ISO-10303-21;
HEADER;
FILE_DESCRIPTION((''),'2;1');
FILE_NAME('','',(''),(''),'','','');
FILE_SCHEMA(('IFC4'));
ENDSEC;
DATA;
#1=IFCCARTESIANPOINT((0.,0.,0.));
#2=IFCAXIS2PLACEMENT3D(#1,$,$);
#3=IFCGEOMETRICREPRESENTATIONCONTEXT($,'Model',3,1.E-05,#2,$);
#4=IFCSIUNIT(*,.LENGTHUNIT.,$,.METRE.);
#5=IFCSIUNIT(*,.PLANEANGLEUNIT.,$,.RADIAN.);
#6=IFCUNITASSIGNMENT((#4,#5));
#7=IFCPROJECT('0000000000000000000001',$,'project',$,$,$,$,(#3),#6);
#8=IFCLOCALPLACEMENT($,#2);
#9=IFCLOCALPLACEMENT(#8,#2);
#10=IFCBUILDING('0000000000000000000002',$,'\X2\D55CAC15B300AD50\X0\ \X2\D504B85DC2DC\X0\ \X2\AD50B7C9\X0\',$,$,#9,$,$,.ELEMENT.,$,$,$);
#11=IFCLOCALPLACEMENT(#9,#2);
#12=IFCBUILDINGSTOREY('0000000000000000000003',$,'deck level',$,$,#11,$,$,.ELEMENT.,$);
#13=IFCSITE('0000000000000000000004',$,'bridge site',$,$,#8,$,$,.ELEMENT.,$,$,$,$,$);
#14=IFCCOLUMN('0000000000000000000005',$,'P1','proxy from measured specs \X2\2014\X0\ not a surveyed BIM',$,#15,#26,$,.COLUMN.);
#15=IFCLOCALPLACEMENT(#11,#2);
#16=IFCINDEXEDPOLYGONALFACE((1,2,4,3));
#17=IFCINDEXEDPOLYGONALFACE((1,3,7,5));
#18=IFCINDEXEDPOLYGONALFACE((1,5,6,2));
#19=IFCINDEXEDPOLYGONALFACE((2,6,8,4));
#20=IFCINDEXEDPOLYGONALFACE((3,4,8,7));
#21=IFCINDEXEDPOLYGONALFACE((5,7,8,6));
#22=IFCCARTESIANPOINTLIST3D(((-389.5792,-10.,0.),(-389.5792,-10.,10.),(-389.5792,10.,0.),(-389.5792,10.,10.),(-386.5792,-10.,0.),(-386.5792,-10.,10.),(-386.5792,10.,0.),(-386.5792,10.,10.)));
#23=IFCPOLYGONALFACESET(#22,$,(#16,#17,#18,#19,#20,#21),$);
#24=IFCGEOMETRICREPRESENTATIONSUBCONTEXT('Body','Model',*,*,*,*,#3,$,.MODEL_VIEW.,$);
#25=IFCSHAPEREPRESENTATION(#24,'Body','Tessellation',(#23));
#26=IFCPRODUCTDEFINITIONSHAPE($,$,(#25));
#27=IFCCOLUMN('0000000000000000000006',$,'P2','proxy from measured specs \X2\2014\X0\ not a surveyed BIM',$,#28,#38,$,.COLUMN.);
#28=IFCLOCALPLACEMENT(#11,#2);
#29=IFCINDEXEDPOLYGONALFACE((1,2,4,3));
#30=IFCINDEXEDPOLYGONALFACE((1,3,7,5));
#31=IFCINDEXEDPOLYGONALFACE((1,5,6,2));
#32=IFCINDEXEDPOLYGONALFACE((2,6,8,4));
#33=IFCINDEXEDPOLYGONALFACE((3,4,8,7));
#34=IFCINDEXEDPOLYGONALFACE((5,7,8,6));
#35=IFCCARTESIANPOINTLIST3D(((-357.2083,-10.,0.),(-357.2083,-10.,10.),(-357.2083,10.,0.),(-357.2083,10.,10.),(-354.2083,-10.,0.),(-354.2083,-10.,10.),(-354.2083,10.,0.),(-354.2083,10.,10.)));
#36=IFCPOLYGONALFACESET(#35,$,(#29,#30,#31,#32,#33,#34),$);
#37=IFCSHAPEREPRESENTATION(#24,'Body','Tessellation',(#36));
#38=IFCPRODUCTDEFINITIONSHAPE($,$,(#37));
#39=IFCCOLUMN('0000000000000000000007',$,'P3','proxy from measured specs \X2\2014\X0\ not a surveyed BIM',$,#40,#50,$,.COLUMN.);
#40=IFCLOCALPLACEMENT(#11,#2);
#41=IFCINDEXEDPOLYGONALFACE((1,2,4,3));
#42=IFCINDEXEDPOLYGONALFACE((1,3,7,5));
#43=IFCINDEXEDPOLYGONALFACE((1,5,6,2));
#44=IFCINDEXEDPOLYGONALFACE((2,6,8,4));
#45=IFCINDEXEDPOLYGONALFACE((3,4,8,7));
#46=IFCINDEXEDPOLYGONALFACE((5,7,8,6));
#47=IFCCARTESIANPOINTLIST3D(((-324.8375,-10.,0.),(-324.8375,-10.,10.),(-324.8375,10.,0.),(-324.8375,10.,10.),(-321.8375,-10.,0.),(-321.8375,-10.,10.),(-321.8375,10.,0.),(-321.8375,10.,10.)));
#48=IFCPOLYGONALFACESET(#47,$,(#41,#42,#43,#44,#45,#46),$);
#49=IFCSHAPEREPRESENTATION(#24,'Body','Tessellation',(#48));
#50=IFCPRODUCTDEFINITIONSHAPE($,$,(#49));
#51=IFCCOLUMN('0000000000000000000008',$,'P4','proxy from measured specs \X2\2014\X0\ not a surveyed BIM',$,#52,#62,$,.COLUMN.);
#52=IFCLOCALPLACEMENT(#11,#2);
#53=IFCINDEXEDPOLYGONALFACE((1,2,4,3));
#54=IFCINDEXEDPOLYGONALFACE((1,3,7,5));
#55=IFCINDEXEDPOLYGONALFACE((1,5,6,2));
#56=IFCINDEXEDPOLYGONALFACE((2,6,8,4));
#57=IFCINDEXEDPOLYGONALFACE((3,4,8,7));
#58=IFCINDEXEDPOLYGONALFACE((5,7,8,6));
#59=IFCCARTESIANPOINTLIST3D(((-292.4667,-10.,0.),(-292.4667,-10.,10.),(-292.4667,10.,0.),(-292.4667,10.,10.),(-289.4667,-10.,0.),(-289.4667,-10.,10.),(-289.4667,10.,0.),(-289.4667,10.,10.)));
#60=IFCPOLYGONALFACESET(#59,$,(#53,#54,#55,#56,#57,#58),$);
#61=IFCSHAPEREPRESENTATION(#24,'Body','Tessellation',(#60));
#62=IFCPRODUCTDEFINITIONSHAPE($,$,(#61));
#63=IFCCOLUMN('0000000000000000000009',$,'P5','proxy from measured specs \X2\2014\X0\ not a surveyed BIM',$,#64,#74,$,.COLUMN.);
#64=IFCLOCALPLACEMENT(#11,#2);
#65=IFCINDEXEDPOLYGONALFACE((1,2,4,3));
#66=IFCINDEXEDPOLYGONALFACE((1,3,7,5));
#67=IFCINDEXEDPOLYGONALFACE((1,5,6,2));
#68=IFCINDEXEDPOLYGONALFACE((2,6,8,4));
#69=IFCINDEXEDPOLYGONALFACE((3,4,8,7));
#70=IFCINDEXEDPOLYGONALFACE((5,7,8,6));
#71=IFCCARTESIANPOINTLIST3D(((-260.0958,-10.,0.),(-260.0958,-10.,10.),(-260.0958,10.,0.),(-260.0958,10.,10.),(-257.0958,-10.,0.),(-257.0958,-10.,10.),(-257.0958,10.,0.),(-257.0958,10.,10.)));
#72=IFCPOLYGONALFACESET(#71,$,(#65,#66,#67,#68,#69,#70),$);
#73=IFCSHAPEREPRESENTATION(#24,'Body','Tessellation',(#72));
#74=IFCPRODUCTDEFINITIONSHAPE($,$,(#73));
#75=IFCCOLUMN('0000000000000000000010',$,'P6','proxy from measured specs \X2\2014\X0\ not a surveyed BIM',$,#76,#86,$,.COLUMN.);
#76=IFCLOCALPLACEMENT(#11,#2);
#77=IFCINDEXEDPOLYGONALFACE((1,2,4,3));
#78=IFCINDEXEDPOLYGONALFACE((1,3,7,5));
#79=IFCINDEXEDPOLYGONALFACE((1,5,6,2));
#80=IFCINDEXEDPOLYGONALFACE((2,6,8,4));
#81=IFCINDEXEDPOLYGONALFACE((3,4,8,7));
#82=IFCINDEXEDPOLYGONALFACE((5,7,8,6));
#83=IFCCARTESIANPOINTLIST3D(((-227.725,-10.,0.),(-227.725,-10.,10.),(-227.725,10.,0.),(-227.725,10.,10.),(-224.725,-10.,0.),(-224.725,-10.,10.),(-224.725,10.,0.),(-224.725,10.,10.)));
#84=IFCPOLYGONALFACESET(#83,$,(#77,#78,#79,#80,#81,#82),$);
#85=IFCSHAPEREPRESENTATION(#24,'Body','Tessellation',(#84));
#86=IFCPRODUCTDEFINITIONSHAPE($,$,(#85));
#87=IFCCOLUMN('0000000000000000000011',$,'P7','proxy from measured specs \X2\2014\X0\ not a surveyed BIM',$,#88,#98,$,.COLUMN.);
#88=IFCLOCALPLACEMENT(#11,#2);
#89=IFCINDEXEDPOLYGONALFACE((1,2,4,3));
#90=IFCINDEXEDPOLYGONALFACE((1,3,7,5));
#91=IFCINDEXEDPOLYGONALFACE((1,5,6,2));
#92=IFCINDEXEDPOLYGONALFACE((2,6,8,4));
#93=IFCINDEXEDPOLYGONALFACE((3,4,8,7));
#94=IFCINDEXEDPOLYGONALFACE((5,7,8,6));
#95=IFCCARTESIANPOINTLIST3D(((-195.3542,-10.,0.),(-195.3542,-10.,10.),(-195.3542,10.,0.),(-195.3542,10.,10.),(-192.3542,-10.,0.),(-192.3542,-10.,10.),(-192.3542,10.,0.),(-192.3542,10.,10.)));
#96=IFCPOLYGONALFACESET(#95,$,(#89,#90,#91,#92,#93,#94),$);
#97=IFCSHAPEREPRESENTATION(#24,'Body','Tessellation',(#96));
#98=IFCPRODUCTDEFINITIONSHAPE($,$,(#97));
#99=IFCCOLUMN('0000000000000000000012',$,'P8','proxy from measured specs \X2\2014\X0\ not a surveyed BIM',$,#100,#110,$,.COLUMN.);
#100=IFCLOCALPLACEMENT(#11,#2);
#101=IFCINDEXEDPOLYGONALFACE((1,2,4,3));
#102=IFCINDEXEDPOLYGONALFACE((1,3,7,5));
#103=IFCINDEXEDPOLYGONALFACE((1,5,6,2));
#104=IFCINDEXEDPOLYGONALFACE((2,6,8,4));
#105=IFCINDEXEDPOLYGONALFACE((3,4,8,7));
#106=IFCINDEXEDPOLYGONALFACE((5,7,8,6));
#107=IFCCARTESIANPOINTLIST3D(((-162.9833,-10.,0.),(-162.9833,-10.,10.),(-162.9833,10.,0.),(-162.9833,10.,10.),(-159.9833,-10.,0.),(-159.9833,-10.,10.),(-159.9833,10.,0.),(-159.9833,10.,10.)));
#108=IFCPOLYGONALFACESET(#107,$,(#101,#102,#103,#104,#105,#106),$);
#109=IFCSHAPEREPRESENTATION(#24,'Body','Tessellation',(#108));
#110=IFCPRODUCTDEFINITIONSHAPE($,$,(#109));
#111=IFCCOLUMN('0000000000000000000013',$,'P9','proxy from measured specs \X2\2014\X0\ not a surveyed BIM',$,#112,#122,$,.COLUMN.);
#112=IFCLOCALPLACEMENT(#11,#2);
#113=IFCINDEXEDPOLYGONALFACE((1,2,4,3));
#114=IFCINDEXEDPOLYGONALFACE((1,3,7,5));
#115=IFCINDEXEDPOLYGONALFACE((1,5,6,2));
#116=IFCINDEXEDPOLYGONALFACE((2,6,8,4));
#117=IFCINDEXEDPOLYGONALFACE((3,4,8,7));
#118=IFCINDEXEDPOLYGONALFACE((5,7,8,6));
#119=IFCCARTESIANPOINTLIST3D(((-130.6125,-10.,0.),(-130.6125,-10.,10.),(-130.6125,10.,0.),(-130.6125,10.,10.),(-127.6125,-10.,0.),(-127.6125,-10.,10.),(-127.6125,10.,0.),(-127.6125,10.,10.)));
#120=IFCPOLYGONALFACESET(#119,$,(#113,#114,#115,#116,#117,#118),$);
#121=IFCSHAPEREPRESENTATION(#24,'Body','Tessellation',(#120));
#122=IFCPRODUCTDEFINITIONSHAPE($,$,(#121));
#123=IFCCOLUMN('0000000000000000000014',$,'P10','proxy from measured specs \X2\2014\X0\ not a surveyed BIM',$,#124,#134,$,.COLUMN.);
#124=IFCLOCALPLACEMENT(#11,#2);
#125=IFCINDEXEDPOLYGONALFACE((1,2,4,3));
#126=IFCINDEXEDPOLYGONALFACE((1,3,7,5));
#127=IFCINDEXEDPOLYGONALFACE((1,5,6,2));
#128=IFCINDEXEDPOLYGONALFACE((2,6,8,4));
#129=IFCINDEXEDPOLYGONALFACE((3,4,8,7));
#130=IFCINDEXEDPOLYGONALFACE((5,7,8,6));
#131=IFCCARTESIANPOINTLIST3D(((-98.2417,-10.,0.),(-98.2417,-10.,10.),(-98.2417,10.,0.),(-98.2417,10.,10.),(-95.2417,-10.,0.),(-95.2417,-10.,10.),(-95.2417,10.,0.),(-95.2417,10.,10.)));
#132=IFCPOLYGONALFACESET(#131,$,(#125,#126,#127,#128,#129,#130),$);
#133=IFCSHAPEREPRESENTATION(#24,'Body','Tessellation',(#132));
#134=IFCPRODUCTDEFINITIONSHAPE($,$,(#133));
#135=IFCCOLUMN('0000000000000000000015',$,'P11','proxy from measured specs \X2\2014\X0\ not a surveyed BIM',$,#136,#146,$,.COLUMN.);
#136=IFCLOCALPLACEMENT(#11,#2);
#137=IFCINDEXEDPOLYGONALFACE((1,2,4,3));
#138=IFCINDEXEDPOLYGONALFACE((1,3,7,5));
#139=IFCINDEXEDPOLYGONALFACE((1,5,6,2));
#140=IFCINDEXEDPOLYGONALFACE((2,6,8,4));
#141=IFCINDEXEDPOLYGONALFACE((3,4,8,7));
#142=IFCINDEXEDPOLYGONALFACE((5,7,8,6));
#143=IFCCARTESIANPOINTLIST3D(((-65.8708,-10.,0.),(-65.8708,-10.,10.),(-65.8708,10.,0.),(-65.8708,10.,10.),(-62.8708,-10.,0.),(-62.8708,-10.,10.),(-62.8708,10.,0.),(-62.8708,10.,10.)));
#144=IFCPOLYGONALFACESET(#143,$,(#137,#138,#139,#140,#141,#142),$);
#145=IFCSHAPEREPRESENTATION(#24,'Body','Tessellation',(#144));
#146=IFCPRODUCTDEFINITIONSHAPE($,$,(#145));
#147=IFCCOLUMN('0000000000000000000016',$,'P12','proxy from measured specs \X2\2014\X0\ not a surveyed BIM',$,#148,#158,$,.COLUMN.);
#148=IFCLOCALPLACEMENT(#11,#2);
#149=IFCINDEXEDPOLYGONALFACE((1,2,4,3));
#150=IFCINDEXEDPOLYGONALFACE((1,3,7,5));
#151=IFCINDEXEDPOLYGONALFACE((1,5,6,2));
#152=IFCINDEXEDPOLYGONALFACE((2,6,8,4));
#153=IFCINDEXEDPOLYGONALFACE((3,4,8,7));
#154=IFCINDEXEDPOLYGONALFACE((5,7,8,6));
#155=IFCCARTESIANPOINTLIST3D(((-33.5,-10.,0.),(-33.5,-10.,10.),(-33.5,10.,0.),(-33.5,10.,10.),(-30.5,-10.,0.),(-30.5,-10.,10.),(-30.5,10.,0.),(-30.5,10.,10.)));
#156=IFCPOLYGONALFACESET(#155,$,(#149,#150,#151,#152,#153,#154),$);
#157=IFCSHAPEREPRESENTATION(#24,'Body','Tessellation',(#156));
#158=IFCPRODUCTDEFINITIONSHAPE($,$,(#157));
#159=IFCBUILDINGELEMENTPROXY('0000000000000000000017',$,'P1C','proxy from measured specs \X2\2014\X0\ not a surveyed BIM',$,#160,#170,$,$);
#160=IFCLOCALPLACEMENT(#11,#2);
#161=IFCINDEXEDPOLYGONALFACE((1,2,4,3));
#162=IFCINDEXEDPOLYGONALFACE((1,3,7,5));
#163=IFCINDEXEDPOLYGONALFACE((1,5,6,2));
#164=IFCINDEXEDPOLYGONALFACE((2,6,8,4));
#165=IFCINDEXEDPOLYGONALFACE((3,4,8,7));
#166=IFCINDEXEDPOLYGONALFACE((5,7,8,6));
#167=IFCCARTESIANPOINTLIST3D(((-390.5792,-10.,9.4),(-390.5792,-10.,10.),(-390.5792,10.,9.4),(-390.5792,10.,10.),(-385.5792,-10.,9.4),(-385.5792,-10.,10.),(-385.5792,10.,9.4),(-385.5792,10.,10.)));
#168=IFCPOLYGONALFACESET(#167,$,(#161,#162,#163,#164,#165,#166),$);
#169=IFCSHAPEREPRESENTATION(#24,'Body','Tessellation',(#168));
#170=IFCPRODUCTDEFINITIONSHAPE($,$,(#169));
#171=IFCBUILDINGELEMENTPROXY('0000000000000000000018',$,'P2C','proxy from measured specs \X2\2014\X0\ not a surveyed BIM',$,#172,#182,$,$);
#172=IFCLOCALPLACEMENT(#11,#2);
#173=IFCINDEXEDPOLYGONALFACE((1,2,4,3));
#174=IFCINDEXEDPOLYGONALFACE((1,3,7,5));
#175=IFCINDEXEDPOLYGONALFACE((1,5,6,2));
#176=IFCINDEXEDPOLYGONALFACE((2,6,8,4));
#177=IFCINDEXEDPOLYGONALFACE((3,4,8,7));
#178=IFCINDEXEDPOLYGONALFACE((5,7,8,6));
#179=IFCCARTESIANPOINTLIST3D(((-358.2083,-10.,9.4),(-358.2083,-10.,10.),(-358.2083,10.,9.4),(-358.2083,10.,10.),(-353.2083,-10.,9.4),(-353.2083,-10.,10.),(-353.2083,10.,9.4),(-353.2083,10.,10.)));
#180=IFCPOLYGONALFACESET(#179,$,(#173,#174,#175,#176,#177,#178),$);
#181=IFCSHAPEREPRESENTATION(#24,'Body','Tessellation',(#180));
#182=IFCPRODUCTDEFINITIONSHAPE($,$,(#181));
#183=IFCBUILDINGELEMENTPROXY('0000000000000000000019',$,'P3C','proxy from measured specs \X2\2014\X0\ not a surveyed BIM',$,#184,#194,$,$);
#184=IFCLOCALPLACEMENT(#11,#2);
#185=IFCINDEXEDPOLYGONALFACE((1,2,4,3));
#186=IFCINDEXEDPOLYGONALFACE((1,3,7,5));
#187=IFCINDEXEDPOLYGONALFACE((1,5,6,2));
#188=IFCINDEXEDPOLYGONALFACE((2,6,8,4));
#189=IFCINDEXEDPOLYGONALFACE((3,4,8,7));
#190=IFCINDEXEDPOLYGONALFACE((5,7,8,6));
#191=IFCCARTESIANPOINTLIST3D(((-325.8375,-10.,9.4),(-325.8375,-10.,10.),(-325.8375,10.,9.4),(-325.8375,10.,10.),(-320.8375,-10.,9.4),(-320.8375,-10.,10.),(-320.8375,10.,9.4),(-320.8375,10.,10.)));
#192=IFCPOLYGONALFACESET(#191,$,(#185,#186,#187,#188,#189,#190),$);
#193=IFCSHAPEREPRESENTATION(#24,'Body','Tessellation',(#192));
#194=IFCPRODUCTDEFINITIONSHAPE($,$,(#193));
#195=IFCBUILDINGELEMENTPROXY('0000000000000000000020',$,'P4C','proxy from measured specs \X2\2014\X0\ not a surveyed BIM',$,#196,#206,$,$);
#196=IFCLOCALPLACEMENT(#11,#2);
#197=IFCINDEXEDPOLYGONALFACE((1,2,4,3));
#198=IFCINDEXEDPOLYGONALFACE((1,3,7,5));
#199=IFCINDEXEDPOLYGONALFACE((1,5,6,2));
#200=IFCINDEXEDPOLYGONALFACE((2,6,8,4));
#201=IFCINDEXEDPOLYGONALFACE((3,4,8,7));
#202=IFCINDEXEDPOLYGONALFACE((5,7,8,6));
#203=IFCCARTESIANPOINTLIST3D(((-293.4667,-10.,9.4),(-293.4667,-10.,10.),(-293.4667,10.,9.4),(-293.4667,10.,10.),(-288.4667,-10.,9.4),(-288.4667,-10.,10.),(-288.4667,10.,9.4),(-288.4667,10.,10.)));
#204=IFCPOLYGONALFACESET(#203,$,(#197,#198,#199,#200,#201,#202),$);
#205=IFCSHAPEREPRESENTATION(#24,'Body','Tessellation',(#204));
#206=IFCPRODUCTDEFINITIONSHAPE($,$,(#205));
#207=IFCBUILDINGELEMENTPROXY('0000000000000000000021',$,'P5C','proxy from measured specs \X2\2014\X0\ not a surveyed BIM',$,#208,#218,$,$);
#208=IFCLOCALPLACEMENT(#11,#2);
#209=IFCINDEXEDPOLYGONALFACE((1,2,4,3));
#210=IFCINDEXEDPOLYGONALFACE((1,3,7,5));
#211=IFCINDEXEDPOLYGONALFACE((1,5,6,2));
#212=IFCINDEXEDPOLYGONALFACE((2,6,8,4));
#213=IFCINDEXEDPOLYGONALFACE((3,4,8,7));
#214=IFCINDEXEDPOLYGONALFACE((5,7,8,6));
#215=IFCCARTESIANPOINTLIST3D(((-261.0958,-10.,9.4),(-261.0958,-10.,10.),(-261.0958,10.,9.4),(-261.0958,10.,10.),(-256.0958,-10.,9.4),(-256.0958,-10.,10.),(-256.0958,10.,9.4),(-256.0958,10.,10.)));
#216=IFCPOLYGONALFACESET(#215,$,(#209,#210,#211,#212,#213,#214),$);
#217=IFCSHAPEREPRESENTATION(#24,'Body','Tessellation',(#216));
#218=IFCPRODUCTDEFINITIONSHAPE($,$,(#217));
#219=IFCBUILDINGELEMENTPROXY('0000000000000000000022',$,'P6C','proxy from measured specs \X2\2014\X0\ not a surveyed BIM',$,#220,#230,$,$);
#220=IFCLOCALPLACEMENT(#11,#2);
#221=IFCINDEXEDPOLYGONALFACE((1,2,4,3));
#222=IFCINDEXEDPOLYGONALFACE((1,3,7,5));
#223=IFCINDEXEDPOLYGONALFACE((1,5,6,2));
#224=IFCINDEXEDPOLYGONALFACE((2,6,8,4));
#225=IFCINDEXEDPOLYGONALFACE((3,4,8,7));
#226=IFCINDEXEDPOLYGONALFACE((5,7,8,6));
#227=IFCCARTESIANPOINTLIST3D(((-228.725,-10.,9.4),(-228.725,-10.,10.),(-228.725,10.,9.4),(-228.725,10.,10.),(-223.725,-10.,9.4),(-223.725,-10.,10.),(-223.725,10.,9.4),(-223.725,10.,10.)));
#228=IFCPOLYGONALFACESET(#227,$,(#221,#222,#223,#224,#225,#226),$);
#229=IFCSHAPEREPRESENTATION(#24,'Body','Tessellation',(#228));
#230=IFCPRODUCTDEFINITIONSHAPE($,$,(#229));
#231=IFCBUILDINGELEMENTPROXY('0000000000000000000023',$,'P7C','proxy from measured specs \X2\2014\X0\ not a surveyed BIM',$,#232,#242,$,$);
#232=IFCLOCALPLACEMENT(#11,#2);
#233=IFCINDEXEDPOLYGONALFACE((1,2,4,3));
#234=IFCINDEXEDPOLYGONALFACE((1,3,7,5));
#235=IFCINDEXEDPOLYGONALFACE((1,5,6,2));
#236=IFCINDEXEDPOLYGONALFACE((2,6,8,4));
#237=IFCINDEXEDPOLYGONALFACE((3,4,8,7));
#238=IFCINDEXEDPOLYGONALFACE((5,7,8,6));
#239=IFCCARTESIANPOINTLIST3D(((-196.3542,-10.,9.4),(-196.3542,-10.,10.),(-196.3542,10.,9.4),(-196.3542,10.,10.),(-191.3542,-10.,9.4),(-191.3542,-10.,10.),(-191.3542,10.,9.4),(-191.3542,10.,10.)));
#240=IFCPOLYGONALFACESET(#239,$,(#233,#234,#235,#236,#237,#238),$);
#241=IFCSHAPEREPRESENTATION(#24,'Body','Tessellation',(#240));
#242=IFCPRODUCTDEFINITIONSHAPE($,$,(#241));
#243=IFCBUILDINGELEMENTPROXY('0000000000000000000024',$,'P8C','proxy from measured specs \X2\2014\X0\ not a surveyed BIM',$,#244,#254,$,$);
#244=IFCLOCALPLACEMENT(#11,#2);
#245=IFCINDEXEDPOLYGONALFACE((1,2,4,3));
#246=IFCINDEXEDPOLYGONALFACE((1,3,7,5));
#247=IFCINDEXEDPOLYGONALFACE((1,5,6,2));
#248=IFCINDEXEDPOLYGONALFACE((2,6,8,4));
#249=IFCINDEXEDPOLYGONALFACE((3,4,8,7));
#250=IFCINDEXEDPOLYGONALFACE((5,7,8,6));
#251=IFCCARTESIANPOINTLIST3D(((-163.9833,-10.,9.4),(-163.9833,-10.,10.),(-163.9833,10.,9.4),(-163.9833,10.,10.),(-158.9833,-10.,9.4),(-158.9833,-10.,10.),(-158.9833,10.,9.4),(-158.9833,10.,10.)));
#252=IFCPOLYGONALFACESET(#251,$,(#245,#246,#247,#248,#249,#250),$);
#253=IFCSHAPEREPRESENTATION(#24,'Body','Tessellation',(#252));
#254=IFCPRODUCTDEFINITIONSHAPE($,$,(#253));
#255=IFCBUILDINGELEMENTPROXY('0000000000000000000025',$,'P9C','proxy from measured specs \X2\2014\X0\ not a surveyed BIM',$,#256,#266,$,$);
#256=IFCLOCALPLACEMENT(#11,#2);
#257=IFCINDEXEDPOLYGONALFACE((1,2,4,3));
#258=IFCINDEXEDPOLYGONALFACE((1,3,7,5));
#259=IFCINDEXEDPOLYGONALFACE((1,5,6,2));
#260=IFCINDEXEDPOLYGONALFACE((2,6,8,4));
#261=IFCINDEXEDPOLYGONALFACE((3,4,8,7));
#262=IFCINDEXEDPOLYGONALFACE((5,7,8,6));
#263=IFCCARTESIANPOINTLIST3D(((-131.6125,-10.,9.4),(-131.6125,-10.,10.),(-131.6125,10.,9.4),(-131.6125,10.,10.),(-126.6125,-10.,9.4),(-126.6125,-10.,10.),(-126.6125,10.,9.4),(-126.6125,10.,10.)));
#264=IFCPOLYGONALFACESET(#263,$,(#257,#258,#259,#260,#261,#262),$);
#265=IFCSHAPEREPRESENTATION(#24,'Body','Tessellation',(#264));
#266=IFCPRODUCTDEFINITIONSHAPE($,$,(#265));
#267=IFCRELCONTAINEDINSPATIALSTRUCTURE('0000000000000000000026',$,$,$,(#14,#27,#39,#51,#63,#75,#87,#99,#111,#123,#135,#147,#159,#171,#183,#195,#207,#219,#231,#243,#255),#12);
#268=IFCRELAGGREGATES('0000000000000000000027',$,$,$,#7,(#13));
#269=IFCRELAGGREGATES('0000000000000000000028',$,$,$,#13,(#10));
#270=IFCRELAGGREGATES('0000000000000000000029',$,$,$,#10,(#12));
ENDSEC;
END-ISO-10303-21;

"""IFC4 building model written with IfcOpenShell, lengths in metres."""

from ifc_helpers import new_model, si_unit, frame, origin, origin_2d, place, context, subcontext, project, spatial, rectangle, extrude, element, save


model = new_model("IFC4")

# Units and contexts
model_context = context("Model", 3, precision=1e-05, world=origin())
body_context = subcontext(model_context, "Body", "Model", "MODEL_VIEW")
ifc_project = project(units=[si_unit("LENGTHUNIT", "METRE"), si_unit("PLANEANGLEUNIT", "RADIAN")], contexts=[model_context])

# Site, building, storey
site_placement = place(None, origin())
site = spatial("IfcSite", under=ifc_project, at=site_placement, Name="bridge site", CompositionType="ELEMENT")
building_placement = place(site_placement, origin())
building = spatial("IfcBuilding", under=site, at=building_placement, Name="한강대교 프록시 교량", CompositionType="ELEMENT")
storey_placement = place(building_placement, origin())
storey = spatial("IfcBuildingStorey", under=building, at=storey_placement, Name="deck level", CompositionType="ELEMENT")

# Columns
for number, where, name in (
    (1, (-388.0792, 0.0, 0.0), "P1"),
    (2, (-355.7083, 0.0, 0.0), "P2"),
    (3, (-323.3375, 0.0, 0.0), "P3"),
    (4, (-290.9667, 0.0, 0.0), "P4"),
    (5, (-258.5958, 0.0, 0.0), "P5"),
    (6, (-226.225, 0.0, 0.0), "P6"),
    (7, (-193.8542, 0.0, 0.0), "P7"),
    (8, (-161.4833, 0.0, 0.0), "P8"),
    (9, (-129.1125, 0.0, 0.0), "P9"),
    (10, (-96.7417, 0.0, 0.0), "P10"),
    (11, (-64.3708, 0.0, 0.0), "P11"),
    (12, (-32.0, 0.0, 0.0), "P12"),
):
    element("IfcColumn", number, at=place(storey_placement, frame(where)), inside=storey, Name=name, Description="proxy from measured specs — not a surveyed BIM", PredefinedType="COLUMN", context=body_context, shape_type="SweptSolid", body=[
        extrude(rectangle(XDim=3.0, YDim=20.0, at=origin_2d()), origin(), (0.0, 0.0, 1.0), 10.0),
    ])

# Building element proxies
for number, where, name in (
    (13, (-388.0792, 0.0, 9.4), "P1C"),
    (14, (-355.7083, 0.0, 9.4), "P2C"),
    (15, (-323.3375, 0.0, 9.4), "P3C"),
    (16, (-290.9667, 0.0, 9.4), "P4C"),
    (17, (-258.5958, 0.0, 9.4), "P5C"),
    (18, (-226.225, 0.0, 9.4), "P6C"),
    (19, (-193.8542, 0.0, 9.4), "P7C"),
    (20, (-161.4833, 0.0, 9.4), "P8C"),
    (21, (-129.1125, 0.0, 9.4), "P9C"),
):
    element("IfcBuildingElementProxy", number, at=place(storey_placement, frame(where)), inside=storey, Name=name, Description="proxy from measured specs — not a surveyed BIM", context=body_context, shape_type="SweptSolid", body=[
        extrude(rectangle(XDim=5.0, YDim=20.0, at=origin_2d()), origin(), (0.0, 0.0, 1.0), 0.6),
    ])

save(model, "model.ifc")
